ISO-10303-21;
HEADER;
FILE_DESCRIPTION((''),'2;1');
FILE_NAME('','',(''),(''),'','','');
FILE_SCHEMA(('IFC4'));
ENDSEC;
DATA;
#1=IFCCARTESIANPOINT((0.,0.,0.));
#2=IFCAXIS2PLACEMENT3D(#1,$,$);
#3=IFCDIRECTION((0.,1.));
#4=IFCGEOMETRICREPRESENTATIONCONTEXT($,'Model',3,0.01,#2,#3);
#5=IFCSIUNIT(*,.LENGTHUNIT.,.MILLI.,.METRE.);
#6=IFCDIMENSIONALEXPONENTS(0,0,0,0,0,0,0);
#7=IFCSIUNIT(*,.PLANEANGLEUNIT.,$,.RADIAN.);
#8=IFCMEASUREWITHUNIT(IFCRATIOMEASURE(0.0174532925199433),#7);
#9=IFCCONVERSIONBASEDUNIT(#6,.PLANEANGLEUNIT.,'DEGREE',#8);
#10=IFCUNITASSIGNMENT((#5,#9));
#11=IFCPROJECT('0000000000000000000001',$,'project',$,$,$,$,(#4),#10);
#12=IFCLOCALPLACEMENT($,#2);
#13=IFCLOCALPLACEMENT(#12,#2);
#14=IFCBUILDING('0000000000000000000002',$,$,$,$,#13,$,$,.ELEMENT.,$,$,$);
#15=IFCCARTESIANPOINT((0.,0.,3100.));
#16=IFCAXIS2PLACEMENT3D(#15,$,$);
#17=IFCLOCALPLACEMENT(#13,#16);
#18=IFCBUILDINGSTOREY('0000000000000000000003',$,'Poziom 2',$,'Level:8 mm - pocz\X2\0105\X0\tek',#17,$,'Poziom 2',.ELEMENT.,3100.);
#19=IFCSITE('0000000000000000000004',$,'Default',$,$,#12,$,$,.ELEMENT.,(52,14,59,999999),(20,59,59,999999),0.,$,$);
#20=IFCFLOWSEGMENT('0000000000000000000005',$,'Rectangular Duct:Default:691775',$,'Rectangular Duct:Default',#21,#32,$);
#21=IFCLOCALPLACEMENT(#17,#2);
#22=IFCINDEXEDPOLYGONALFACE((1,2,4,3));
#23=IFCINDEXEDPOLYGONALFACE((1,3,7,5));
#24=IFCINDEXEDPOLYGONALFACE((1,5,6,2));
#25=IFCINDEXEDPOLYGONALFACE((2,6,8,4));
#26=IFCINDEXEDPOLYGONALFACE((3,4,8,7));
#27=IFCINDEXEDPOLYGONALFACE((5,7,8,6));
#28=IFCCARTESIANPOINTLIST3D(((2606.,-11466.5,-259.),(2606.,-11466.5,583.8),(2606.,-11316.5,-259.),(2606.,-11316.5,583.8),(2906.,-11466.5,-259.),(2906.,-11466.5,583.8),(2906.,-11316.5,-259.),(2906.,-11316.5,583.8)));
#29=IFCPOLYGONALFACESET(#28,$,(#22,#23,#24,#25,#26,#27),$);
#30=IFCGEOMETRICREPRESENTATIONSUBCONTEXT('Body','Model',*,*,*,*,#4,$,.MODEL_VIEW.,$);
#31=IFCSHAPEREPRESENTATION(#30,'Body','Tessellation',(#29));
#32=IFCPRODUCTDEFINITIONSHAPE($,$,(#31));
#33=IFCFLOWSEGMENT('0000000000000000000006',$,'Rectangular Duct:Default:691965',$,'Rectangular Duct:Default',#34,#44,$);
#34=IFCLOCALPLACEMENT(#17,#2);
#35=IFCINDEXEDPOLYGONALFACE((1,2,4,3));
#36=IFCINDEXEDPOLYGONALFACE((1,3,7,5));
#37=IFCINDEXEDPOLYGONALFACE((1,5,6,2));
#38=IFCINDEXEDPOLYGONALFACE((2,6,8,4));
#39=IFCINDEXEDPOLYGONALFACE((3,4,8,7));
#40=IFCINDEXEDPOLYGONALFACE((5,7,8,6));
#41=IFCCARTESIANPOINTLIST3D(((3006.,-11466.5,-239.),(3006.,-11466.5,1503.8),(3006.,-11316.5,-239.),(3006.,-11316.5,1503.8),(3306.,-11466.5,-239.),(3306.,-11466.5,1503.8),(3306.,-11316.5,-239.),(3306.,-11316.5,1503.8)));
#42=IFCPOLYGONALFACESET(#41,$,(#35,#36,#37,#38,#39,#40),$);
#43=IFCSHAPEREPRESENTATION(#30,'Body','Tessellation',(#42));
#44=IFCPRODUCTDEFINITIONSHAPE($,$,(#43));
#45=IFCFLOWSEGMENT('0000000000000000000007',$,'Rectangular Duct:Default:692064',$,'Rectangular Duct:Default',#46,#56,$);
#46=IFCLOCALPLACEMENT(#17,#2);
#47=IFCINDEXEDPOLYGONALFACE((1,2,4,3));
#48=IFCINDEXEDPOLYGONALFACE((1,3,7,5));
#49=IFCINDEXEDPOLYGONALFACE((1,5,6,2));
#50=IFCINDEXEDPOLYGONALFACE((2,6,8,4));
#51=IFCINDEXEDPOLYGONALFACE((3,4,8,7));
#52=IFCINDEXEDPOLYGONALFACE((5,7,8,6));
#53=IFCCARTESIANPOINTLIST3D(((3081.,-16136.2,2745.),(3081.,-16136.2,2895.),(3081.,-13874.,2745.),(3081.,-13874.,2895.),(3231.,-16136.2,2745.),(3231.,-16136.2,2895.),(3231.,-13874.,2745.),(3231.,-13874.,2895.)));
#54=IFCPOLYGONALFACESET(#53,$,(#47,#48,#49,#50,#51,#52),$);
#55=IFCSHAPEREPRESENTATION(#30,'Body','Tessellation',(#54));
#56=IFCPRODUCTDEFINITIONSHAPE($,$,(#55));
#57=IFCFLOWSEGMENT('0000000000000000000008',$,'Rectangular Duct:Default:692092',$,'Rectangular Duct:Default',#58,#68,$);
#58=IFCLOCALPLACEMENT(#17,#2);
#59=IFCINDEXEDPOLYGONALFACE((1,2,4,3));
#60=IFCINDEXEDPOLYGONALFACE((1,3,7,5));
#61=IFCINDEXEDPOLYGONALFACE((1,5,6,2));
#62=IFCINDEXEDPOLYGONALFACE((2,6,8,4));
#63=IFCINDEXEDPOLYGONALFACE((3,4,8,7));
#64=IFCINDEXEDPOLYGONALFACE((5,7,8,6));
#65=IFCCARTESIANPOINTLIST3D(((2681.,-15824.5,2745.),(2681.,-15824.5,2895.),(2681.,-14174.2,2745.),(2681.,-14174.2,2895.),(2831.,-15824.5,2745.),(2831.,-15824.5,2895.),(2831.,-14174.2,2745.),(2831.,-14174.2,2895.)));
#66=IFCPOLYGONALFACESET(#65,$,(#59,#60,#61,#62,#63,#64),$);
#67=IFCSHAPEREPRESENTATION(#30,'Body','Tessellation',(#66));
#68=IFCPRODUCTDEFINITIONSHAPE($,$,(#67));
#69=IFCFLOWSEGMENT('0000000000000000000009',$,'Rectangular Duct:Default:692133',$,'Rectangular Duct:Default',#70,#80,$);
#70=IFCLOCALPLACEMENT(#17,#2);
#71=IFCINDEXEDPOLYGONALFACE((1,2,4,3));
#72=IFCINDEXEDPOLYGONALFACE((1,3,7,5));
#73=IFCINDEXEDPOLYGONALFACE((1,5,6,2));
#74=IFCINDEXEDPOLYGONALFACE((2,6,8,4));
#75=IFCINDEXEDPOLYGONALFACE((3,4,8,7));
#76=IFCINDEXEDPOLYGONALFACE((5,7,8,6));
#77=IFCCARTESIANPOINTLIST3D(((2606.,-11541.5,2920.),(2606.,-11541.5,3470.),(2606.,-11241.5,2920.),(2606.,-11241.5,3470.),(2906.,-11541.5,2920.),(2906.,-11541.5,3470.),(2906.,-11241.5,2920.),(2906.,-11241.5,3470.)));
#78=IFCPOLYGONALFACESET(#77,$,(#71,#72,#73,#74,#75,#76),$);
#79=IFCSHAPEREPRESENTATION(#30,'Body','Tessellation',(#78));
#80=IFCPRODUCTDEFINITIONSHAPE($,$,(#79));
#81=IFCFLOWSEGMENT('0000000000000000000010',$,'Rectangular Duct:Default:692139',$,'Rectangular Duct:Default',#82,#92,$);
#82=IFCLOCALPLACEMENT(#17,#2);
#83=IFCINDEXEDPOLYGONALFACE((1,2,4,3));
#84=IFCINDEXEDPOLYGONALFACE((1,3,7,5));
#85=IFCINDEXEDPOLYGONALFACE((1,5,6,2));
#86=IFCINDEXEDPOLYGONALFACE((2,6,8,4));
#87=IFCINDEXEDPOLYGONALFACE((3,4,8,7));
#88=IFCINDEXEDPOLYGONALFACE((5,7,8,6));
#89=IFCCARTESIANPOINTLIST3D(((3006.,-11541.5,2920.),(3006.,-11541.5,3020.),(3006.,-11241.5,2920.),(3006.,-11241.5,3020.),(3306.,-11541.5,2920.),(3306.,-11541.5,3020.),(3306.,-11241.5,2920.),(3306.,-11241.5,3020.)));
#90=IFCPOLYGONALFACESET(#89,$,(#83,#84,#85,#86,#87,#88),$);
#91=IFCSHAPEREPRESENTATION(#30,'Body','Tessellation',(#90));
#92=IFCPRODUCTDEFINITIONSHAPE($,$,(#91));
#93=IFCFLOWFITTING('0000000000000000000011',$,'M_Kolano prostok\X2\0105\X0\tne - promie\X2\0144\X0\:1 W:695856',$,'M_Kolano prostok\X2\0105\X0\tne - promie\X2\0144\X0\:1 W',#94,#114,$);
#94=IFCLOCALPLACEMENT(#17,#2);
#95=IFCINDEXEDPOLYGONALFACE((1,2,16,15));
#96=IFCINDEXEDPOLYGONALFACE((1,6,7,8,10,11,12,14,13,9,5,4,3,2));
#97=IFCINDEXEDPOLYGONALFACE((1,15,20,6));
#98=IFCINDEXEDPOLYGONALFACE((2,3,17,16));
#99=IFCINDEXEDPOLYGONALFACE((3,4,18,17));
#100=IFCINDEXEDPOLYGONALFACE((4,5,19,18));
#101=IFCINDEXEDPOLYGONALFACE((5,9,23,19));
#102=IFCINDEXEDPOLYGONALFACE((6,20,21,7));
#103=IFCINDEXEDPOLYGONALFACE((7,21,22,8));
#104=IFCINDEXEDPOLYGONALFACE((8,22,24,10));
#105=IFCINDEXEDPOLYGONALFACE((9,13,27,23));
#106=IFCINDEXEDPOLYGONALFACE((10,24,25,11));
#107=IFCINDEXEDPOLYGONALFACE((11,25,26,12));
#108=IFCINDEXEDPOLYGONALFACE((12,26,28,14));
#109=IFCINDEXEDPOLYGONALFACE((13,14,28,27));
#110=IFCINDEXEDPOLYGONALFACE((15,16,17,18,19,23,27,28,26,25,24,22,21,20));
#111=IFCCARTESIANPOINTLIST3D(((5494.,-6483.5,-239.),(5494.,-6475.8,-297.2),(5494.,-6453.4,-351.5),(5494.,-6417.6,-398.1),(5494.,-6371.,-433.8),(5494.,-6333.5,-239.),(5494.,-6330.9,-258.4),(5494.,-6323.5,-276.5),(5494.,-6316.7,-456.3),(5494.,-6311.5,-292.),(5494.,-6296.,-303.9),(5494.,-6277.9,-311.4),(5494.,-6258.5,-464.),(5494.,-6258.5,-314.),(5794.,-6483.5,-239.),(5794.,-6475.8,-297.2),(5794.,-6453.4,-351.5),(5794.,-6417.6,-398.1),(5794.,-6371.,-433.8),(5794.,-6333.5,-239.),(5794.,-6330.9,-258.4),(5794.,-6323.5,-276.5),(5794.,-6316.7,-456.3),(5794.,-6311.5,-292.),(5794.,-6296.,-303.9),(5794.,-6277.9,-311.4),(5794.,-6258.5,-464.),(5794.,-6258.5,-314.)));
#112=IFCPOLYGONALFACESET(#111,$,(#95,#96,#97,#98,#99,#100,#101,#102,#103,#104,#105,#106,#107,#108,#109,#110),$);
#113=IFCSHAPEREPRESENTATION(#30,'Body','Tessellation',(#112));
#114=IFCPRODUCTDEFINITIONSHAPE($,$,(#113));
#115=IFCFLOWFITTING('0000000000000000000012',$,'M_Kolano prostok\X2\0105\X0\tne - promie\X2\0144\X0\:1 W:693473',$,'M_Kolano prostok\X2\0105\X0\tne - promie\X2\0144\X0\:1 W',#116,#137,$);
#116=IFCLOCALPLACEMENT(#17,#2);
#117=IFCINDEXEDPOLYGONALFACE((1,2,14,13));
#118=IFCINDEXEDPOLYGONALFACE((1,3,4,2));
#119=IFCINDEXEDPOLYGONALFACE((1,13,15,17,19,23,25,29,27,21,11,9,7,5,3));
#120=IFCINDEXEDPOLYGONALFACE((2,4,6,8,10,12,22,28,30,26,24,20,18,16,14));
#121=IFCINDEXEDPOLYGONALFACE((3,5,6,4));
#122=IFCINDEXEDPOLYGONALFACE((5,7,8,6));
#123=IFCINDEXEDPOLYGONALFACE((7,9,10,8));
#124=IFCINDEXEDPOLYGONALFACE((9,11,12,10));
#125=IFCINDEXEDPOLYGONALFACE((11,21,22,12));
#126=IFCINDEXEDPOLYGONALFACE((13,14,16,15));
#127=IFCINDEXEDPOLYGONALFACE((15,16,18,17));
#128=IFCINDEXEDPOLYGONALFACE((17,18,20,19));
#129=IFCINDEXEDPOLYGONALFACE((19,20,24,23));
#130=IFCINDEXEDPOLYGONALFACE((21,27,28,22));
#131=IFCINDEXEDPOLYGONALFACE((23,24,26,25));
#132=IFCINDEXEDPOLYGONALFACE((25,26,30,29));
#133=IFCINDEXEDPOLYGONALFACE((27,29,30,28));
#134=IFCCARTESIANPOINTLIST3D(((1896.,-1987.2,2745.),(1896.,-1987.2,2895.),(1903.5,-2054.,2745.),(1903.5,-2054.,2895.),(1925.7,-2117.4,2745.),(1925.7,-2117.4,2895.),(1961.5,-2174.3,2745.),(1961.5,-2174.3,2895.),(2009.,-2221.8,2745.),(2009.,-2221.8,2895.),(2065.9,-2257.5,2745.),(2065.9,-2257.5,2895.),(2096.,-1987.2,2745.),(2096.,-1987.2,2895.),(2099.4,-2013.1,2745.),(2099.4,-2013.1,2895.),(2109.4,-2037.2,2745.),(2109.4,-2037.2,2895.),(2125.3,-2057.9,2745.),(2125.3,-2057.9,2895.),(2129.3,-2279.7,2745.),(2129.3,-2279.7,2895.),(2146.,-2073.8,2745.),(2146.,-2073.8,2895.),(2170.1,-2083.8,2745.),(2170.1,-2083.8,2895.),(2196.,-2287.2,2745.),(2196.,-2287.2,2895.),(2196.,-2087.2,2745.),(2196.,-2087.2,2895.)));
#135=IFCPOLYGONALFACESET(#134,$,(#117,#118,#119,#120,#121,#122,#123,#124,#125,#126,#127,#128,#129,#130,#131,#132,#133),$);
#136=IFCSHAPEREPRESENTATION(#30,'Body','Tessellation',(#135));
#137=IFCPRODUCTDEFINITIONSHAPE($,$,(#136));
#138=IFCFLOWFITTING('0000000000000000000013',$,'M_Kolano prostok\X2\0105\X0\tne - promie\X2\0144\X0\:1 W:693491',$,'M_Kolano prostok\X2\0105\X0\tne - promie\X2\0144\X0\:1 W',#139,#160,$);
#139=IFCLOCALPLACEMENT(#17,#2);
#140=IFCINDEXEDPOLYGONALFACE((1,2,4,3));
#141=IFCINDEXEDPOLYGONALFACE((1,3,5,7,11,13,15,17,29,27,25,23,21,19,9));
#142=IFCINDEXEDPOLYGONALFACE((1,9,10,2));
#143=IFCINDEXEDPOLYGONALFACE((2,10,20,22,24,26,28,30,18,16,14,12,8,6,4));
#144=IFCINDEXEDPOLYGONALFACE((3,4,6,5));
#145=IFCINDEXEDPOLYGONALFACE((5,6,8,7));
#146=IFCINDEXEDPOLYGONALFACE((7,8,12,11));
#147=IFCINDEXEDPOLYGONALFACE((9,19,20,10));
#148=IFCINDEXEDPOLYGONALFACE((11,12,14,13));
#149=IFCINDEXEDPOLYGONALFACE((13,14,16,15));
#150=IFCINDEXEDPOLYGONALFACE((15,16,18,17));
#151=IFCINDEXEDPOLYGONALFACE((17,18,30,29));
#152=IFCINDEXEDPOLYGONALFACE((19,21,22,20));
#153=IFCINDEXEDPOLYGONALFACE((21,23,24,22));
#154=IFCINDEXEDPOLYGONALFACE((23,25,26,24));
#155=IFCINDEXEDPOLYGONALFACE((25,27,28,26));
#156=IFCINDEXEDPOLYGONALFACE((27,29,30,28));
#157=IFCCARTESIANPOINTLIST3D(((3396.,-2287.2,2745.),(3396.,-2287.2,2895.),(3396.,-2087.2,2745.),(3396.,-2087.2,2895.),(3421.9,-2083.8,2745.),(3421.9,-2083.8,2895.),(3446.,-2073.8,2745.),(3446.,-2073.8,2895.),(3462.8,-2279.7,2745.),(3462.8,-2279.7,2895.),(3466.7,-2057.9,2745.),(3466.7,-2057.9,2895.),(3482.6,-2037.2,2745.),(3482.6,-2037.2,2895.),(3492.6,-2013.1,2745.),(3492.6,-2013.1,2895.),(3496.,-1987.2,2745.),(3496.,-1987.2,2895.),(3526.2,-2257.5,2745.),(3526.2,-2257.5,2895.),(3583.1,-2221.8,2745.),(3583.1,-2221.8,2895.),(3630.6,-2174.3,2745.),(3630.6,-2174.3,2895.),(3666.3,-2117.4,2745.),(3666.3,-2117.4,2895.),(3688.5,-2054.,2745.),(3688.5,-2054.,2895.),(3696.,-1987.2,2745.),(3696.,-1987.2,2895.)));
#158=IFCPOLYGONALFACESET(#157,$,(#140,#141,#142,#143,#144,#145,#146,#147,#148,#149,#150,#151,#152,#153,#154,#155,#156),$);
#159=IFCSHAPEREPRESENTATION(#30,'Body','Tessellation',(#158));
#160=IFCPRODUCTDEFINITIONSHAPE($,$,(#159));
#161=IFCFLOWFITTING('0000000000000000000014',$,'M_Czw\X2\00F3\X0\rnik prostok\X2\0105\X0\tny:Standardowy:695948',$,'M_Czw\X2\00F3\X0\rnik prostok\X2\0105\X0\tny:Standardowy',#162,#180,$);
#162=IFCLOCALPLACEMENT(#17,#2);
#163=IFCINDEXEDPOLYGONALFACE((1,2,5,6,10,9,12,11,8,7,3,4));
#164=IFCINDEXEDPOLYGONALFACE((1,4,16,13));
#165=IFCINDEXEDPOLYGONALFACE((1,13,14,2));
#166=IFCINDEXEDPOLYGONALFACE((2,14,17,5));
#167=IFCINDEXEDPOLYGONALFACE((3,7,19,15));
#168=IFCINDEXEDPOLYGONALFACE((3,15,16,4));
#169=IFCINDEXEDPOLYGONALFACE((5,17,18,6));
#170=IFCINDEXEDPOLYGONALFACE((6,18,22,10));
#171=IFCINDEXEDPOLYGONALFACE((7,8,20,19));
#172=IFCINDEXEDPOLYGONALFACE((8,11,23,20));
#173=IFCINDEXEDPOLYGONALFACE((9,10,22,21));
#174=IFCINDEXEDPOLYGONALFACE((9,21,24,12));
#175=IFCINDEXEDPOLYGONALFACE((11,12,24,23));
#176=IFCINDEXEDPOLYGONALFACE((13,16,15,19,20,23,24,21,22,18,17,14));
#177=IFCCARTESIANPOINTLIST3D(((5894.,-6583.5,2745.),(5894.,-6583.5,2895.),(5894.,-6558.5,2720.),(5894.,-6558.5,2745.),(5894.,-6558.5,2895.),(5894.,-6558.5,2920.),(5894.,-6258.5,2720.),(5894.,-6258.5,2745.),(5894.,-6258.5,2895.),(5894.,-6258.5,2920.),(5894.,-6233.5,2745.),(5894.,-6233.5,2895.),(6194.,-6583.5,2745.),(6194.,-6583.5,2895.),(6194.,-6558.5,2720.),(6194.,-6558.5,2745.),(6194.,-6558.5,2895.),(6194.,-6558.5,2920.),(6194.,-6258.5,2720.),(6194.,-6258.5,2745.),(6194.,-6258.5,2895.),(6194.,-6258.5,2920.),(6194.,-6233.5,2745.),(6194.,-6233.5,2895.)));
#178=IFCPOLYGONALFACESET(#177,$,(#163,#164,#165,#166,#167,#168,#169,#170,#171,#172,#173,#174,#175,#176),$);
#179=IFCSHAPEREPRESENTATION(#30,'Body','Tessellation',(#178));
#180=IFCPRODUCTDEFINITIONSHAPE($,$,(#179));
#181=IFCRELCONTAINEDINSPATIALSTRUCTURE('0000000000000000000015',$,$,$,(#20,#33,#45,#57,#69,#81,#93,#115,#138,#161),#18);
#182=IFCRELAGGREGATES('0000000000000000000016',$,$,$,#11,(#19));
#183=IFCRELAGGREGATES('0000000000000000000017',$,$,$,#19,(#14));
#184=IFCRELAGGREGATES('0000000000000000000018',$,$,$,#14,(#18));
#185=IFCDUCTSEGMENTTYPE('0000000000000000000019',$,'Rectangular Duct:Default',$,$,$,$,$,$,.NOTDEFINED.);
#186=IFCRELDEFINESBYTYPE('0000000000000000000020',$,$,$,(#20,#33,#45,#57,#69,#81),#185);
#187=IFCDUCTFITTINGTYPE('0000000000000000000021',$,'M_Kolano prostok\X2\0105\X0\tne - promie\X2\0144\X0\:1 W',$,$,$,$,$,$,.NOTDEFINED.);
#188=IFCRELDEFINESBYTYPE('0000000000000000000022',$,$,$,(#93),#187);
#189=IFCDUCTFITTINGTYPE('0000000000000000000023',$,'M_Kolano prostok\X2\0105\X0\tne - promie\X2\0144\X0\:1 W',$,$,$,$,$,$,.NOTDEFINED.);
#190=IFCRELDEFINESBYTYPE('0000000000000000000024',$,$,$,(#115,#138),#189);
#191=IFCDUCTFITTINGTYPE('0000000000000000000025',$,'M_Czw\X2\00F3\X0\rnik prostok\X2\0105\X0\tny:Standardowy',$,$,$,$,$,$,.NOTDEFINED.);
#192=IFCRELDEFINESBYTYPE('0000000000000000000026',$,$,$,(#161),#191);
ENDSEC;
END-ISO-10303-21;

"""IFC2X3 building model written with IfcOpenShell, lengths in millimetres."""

from ifc_helpers import new_model, entity, si_unit, converted_unit, direction, frame, frame_2d, origin, origin_2d_with_axis, place, context, subcontext, project, spatial, polyline, circle_curve, parameter, trimmed, segment, composite_curve, rectangle, outline, extrude, source, transform, mapped, type_object, type_shapes, element, save


model = new_model("IFC2X3")

# Units and contexts
model_context = context("Model", 3, precision=0.01, world=origin(), true_north=direction((0.0, 1.0)))
body_context = subcontext(model_context, "Body", "Model", "MODEL_VIEW")
ifc_project = project(units=[si_unit("LENGTHUNIT", "METRE", prefix="MILLI"), converted_unit("PLANEANGLEUNIT", "DEGREE", entity("IfcRatioMeasure", 0.0174532925199433), si_unit("PLANEANGLEUNIT", "RADIAN"), dimensions=[0, 0, 0, 0, 0, 0, 0])], contexts=[model_context])

# Site, building, storey
site_placement = place(None, origin())
site = spatial("IfcSite", under=ifc_project, at=site_placement, Name="Default", CompositionType="ELEMENT", RefLatitude=(52, 14, 59, 999999), RefLongitude=(20, 59, 59, 999999), RefElevation=0.0)
building_placement = place(site_placement, origin())
building = spatial("IfcBuilding", under=site, at=building_placement, CompositionType="ELEMENT")
storey_placement = place(building_placement, frame((0.0, 0.0, 3100.0)))
storey = spatial("IfcBuildingStorey", under=building, at=storey_placement, Name="Poziom 2", ObjectType="Level:8 mm - początek", LongName="Poziom 2", CompositionType="ELEMENT", Elevation=3100.0)

# Flow segments
duct_segment_type = type_object("IfcDuctSegmentType", Name="Rectangular Duct:Default", PredefinedType="NOTDEFINED")
flow_segment_1_placement = place(storey_placement, origin())
element("IfcFlowSegment", 1, at=flow_segment_1_placement, inside=storey, type_object=duct_segment_type, Name="Rectangular Duct:Default:691775", ObjectType="Rectangular Duct:Default", context=body_context, shape_type="SweptSolid", body=[
    extrude(rectangle(XDim=150.0, YDim=300.0, at=origin_2d_with_axis()), frame((2756.0, -11391.5, -259.0), z_axis=(0.0, 0.0, 1.0), x_axis=(0.0, 1.0, 0.0)), (0.0, 0.0, 1.0), 842.8),
])
flow_segment_2_placement = place(storey_placement, origin())
element("IfcFlowSegment", 2, at=flow_segment_2_placement, inside=storey, type_object=duct_segment_type, Name="Rectangular Duct:Default:691965", ObjectType="Rectangular Duct:Default", context=body_context, shape_type="SweptSolid", body=[
    extrude(rectangle(XDim=150.0, YDim=300.0, at=origin_2d_with_axis()), frame((3156.0, -11391.5, -239.0), z_axis=(0.0, 0.0, 1.0), x_axis=(0.0, 1.0, 0.0)), (0.0, 0.0, 1.0), 1742.8),
])
flow_segment_3_placement = place(storey_placement, origin())
element("IfcFlowSegment", 3, at=flow_segment_3_placement, inside=storey, type_object=duct_segment_type, Name="Rectangular Duct:Default:692064", ObjectType="Rectangular Duct:Default", context=body_context, shape_type="SweptSolid", body=[
    extrude(rectangle(XDim=2262.2, YDim=150.0, at=frame_2d((0.0, 0.0), x_axis=(1.0, 0.0))), frame((3156.0, -15005.1, 2745.0), z_axis=(0.0, 0.0, 1.0), x_axis=(0.0, -1.0, 0.0)), (0.0, 0.0, 1.0), 150.0),
])
flow_segment_4_placement = place(storey_placement, origin())
element("IfcFlowSegment", 4, at=flow_segment_4_placement, inside=storey, type_object=duct_segment_type, Name="Rectangular Duct:Default:692092", ObjectType="Rectangular Duct:Default", context=body_context, shape_type="SweptSolid", body=[
    extrude(rectangle(XDim=1650.4, YDim=150.0, at=frame_2d((0.0, 0.0), x_axis=(1.0, 0.0))), frame((2756.0, -14999.4, 2745.0), z_axis=(0.0, 0.0, 1.0), x_axis=(0.0, -1.0, 0.0)), (0.0, 0.0, 1.0), 150.0),
])
flow_segment_5_placement = place(storey_placement, origin())
element("IfcFlowSegment", 5, at=flow_segment_5_placement, inside=storey, type_object=duct_segment_type, Name="Rectangular Duct:Default:692133", ObjectType="Rectangular Duct:Default", context=body_context, shape_type="SweptSolid", body=[
    extrude(rectangle(XDim=300.0, YDim=300.0, at=frame_2d((0.0, 0.0), x_axis=(1.0, 0.0))), frame((2756.0, -11391.5, 2920.0), z_axis=(0.0, 0.0, 1.0), x_axis=(0.0, -1.0, 0.0)), (0.0, 0.0, 1.0), 550.0),
])
flow_segment_6_placement = place(storey_placement, origin())
element("IfcFlowSegment", 6, at=flow_segment_6_placement, inside=storey, type_object=duct_segment_type, Name="Rectangular Duct:Default:692139", ObjectType="Rectangular Duct:Default", context=body_context, shape_type="SweptSolid", body=[
    extrude(rectangle(XDim=300.0, YDim=300.0, at=origin_2d_with_axis()), frame((3156.0, -11391.5, 2920.0), z_axis=(0.0, 0.0, 1.0), x_axis=(0.0, -1.0, 0.0)), (0.0, 0.0, 1.0), 100.0),
])

# Flow fittings
duct_fitting_type_1 = type_object("IfcDuctFittingType", Name="M_Kolano prostokątne - promień:1 W", PredefinedType="NOTDEFINED")
shared_shape_1 = source(origin(), body_context, "Body", "SweptSolid", [
    extrude(outline(composite_curve([segment(polyline([(-150.0, -75.0), (0.0, -75.0)]), True, "CONTINUOUS"), segment(trimmed(circle_curve(frame_2d((75.0, -75.0), x_axis=(0.0, 1.0)), 75.0), [parameter(0.0)], [parameter(90.0)], True, "PARAMETER"), False, "CONTINUOUS"), segment(polyline([(75.0, 0.0), (75.0, 150.0)]), True, "CONTINUOUS"), segment(trimmed(circle_curve(frame_2d((75.0, -75.0), x_axis=(0.0, 1.0)), 225.0), [parameter(0.0)], [parameter(90.0)], True, "PARAMETER"), True, "CONTINUOUS")], self_intersect=False)), frame((-75.0, 75.0, -150.0), z_axis=(0.0, 0.0, 1.0), x_axis=(-1.0, 0.0, 0.0)), (0.0, 0.0, 1.0), 300.0),
])
type_shapes(duct_fitting_type_1, [shared_shape_1])
flow_fitting_1_placement = place(storey_placement, frame((5644.0, -6408.5, -389.0), z_axis=(1.0, 0.0, 0.0), x_axis=(0.0, 0.0, -1.0)))
element("IfcFlowFitting", 7, at=flow_fitting_1_placement, inside=storey, type_object=duct_fitting_type_1, Name="M_Kolano prostokątne - promień:1 W:695856", ObjectType="M_Kolano prostokątne - promień:1 W", context=body_context, shape_type="MappedRepresentation", body=[
    mapped(shared_shape_1, transform((0.0, 0.0, 0.0), scale=1.0)),
])
duct_fitting_type_2 = type_object("IfcDuctFittingType", Name="M_Kolano prostokątne - promień:1 W", PredefinedType="NOTDEFINED")
shared_shape_2 = source(origin(), body_context, "Body", "SweptSolid", [
    extrude(outline(composite_curve([segment(polyline([(-200.0, -100.0), (0.0, -100.0)]), True, "CONTINUOUS"), segment(trimmed(circle_curve(frame_2d((100.0, -100.0), x_axis=(0.0, 1.0)), 100.0), [parameter(0.0)], [parameter(90.0)], True, "PARAMETER"), False, "CONTINUOUS"), segment(polyline([(100.0, 0.0), (100.0, 200.0)]), True, "CONTINUOUS"), segment(trimmed(circle_curve(frame_2d((100.0, -100.0), x_axis=(0.0, 1.0)), 300.0), [parameter(0.0)], [parameter(90.0)], True, "PARAMETER"), True, "CONTINUOUS")], self_intersect=False)), frame((-100.0, 100.0, -75.0), z_axis=(0.0, 0.0, 1.0), x_axis=(-1.0, 0.0, 0.0)), (0.0, 0.0, 1.0), 150.0),
])
type_shapes(duct_fitting_type_2, [shared_shape_2])
flow_fitting_2_placement = place(storey_placement, frame((1996.0, -2187.2, 2820.0), z_axis=(0.0, 0.0, 1.0), x_axis=(0.0, -1.0, 0.0)))
element("IfcFlowFitting", 8, at=flow_fitting_2_placement, inside=storey, type_object=duct_fitting_type_2, Name="M_Kolano prostokątne - promień:1 W:693473", ObjectType="M_Kolano prostokątne - promień:1 W", context=body_context, shape_type="MappedRepresentation", body=[
    mapped(shared_shape_2, transform((0.0, 0.0, 0.0), scale=1.0)),
])
flow_fitting_3_placement = place(storey_placement, frame((3596.0, -2187.2, 2820.0)))
element("IfcFlowFitting", 9, at=flow_fitting_3_placement, inside=storey, type_object=duct_fitting_type_2, Name="M_Kolano prostokątne - promień:1 W:693491", ObjectType="M_Kolano prostokątne - promień:1 W", context=body_context, shape_type="MappedRepresentation", body=[
    mapped(shared_shape_2, transform((0.0, 0.0, 0.0), scale=1.0)),
])
duct_fitting_type_3 = type_object("IfcDuctFittingType", Name="M_Czwórnik prostokątny:Standardowy", PredefinedType="NOTDEFINED")
shared_shape_3 = source(origin(), body_context, "Body", "SweptSolid", [
    extrude(outline(polyline([(-175.0, 75.0), (-175.0, -75.0), (-150.0, -75.0), (-150.0, -100.0), (150.0, -100.0), (150.0, -75.0), (175.0, -75.0), (175.0, 75.0), (150.0, 75.0), (150.0, 100.0), (-150.0, 100.0), (-150.0, 75.0), (-175.0, 75.0)])), frame((0.0, 0.0, -150.0), z_axis=(0.0, 0.0, -1.0), x_axis=(0.0, 1.0, 0.0)), (0.0, 0.0, -1.0), 300.0),
])
type_shapes(duct_fitting_type_3, [shared_shape_3])
for number, where, z_axis, x_axis, name in (
    (10, (6044.0, -6408.5, 2820.0), (-1.0, 0.0, 0.0), (0.0, 0.0, 1.0), "M_Czwórnik prostokątny:Standardowy:695948"),
):
    element("IfcFlowFitting", number, at=place(storey_placement, frame(where, z_axis=z_axis, x_axis=x_axis)), inside=storey, type_object=duct_fitting_type_3, Name=name, ObjectType="M_Czwórnik prostokątny:Standardowy", context=body_context, shape_type="MappedRepresentation", body=[
        mapped(shared_shape_3, transform((0.0, 0.0, 0.0), scale=1.0)),
    ])

save(model, "model.ifc")
